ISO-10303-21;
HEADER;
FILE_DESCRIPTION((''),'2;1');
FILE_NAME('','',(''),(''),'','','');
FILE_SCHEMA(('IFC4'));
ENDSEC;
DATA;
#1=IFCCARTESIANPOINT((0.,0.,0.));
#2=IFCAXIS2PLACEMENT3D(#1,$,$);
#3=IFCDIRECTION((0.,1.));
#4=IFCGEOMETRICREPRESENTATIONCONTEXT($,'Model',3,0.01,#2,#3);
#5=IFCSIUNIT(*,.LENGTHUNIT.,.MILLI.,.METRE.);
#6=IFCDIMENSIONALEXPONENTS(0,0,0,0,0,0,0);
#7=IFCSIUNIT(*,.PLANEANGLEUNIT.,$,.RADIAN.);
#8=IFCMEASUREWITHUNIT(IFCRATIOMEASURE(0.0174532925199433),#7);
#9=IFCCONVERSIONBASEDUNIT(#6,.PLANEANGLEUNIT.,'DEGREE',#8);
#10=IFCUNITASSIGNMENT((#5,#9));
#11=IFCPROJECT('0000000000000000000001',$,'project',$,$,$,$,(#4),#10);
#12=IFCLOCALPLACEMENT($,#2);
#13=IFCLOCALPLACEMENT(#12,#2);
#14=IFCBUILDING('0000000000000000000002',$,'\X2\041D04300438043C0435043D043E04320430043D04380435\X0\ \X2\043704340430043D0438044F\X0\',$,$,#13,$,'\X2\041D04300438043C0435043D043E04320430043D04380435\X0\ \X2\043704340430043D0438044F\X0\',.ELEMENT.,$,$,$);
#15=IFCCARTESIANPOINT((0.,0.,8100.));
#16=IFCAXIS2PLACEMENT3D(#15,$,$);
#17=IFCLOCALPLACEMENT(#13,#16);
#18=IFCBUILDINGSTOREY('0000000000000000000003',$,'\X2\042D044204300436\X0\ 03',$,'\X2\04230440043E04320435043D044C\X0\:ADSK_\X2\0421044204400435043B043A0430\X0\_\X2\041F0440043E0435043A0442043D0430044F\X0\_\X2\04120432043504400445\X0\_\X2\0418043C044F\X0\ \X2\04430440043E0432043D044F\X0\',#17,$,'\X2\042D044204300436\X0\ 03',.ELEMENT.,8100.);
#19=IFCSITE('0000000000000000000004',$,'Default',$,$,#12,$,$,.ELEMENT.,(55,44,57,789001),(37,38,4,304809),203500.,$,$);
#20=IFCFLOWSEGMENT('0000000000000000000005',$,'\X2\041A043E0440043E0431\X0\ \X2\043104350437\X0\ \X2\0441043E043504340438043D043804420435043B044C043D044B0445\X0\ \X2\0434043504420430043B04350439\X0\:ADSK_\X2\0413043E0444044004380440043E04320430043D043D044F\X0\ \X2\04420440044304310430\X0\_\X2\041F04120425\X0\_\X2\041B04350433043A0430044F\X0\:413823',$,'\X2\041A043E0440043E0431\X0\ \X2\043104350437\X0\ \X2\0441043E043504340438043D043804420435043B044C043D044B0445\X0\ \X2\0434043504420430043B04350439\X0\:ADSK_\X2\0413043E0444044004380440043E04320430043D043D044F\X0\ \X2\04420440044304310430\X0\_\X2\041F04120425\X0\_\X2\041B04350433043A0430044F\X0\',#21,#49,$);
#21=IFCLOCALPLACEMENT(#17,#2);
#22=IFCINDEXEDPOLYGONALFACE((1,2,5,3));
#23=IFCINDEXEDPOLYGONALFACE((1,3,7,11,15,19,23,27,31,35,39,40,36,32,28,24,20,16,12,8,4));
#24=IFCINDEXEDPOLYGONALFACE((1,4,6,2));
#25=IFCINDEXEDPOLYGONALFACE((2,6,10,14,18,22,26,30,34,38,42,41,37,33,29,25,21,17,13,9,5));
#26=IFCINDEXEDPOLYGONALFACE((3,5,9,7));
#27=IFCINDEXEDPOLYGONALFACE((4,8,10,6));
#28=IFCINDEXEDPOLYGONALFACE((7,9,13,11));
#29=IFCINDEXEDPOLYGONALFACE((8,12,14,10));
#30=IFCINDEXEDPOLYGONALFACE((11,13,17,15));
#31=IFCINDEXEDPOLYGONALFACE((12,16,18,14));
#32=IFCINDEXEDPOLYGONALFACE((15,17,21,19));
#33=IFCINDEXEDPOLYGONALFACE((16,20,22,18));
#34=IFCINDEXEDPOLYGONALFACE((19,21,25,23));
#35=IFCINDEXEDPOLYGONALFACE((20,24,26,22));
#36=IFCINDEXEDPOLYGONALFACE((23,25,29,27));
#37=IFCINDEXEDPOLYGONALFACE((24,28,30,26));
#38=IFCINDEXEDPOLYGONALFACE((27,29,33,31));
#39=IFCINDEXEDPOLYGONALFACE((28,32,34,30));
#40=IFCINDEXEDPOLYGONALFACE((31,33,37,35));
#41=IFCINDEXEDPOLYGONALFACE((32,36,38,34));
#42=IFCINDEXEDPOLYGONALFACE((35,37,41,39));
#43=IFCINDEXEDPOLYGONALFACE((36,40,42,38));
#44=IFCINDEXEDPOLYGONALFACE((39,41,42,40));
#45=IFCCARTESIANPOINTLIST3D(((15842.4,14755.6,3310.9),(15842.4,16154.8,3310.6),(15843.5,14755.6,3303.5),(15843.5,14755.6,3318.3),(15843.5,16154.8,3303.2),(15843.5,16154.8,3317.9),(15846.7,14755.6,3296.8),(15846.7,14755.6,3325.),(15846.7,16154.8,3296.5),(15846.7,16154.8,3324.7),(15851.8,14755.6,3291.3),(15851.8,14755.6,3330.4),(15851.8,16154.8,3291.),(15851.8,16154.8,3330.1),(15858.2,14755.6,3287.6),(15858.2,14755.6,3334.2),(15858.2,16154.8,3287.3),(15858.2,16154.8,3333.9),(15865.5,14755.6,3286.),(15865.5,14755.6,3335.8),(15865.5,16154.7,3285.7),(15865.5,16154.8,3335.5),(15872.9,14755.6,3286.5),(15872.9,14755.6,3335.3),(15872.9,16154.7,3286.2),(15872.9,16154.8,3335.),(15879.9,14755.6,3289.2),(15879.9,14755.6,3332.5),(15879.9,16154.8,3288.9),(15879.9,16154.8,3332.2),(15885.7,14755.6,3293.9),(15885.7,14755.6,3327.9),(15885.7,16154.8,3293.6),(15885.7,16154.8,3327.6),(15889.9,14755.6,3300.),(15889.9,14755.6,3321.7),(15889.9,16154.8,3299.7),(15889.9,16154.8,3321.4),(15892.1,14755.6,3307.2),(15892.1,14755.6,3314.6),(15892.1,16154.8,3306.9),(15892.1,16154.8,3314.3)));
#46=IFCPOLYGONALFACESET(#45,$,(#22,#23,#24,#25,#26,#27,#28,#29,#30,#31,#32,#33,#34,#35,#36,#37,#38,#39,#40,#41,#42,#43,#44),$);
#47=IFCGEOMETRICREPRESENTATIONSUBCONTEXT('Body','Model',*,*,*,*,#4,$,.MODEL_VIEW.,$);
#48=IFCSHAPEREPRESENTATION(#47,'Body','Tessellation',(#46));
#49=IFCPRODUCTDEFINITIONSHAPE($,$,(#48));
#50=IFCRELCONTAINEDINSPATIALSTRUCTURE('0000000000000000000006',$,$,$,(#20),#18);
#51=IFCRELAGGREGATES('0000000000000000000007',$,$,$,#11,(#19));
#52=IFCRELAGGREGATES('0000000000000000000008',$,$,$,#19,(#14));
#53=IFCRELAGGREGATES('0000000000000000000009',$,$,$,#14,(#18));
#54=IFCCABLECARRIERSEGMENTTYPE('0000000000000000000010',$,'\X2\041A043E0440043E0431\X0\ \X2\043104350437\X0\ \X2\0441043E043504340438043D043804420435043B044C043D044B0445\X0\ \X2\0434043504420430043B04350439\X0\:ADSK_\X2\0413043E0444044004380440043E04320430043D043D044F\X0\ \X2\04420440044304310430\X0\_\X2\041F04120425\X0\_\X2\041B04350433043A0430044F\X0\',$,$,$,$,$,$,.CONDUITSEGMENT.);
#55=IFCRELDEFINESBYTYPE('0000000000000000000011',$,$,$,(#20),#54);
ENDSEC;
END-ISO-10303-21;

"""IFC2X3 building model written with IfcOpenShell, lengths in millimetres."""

from ifc_helpers import new_model, entity, si_unit, converted_unit, direction, frame, frame_2d, origin, place, context, subcontext, project, spatial, circle, extrude, type_object, element, save


model = new_model("IFC2X3")

# Units and contexts
model_context = context("Model", 3, precision=0.01, world=origin(), true_north=direction((0.0, 1.0)))
body_context = subcontext(model_context, "Body", "Model", "MODEL_VIEW")
ifc_project = project(units=[si_unit("LENGTHUNIT", "METRE", prefix="MILLI"), converted_unit("PLANEANGLEUNIT", "DEGREE", entity("IfcRatioMeasure", 0.0174532925199433), si_unit("PLANEANGLEUNIT", "RADIAN"), dimensions=[0, 0, 0, 0, 0, 0, 0])], contexts=[model_context])

# Site, building, storey
site_placement = place(None, frame((0.0, 0.0, 0.0)))
site = spatial("IfcSite", under=ifc_project, at=site_placement, Name="Default", CompositionType="ELEMENT", RefLatitude=(55, 44, 57, 789001), RefLongitude=(37, 38, 4, 304809), RefElevation=203500.0)
building_placement = place(site_placement, origin())
building = spatial("IfcBuilding", under=site, at=building_placement, Name="Наименование здания", LongName="Наименование здания", CompositionType="ELEMENT")
storey_placement = place(building_placement, frame((0.0, 0.0, 8100.0)))
storey = spatial("IfcBuildingStorey", under=building, at=storey_placement, Name="Этаж 03", ObjectType="Уровень:ADSK_Стрелка_Проектная_Вверх_Имя уровня", LongName="Этаж 03", CompositionType="ELEMENT", Elevation=8100.0)

# Flow segment
cable_carrier_segment_type = type_object("IfcCableCarrierSegmentType", Name="Короб без соединительных деталей:ADSK_Гофрировання труба_ПВХ_Легкая", PredefinedType="CONDUITSEGMENT")
flow_segment_1_placement = place(storey_placement, frame((15840.8, 14755.6, 3284.0)))
element("IfcFlowSegment", 1, at=flow_segment_1_placement, inside=storey, type_object=cable_carrier_segment_type, Name="Короб без соединительных деталей:ADSK_Гофрировання труба_ПВХ_Легкая:413823", ObjectType="Короб без соединительных деталей:ADSK_Гофрировання труба_ПВХ_Легкая", context=body_context, shape_type="SweptSolid", body=[
    extrude(circle(Radius=25.0, at=frame_2d((0.0, 0.0), x_axis=(1.0, 0.0))), frame((26.6, 0.0, 26.9), z_axis=(0.0, 1.0, -0.000223), x_axis=(-1.0, 0.0, 0.0)), (0.0, 0.0, 1.0), 1399.1),
])

save(model, "model.ifc")
